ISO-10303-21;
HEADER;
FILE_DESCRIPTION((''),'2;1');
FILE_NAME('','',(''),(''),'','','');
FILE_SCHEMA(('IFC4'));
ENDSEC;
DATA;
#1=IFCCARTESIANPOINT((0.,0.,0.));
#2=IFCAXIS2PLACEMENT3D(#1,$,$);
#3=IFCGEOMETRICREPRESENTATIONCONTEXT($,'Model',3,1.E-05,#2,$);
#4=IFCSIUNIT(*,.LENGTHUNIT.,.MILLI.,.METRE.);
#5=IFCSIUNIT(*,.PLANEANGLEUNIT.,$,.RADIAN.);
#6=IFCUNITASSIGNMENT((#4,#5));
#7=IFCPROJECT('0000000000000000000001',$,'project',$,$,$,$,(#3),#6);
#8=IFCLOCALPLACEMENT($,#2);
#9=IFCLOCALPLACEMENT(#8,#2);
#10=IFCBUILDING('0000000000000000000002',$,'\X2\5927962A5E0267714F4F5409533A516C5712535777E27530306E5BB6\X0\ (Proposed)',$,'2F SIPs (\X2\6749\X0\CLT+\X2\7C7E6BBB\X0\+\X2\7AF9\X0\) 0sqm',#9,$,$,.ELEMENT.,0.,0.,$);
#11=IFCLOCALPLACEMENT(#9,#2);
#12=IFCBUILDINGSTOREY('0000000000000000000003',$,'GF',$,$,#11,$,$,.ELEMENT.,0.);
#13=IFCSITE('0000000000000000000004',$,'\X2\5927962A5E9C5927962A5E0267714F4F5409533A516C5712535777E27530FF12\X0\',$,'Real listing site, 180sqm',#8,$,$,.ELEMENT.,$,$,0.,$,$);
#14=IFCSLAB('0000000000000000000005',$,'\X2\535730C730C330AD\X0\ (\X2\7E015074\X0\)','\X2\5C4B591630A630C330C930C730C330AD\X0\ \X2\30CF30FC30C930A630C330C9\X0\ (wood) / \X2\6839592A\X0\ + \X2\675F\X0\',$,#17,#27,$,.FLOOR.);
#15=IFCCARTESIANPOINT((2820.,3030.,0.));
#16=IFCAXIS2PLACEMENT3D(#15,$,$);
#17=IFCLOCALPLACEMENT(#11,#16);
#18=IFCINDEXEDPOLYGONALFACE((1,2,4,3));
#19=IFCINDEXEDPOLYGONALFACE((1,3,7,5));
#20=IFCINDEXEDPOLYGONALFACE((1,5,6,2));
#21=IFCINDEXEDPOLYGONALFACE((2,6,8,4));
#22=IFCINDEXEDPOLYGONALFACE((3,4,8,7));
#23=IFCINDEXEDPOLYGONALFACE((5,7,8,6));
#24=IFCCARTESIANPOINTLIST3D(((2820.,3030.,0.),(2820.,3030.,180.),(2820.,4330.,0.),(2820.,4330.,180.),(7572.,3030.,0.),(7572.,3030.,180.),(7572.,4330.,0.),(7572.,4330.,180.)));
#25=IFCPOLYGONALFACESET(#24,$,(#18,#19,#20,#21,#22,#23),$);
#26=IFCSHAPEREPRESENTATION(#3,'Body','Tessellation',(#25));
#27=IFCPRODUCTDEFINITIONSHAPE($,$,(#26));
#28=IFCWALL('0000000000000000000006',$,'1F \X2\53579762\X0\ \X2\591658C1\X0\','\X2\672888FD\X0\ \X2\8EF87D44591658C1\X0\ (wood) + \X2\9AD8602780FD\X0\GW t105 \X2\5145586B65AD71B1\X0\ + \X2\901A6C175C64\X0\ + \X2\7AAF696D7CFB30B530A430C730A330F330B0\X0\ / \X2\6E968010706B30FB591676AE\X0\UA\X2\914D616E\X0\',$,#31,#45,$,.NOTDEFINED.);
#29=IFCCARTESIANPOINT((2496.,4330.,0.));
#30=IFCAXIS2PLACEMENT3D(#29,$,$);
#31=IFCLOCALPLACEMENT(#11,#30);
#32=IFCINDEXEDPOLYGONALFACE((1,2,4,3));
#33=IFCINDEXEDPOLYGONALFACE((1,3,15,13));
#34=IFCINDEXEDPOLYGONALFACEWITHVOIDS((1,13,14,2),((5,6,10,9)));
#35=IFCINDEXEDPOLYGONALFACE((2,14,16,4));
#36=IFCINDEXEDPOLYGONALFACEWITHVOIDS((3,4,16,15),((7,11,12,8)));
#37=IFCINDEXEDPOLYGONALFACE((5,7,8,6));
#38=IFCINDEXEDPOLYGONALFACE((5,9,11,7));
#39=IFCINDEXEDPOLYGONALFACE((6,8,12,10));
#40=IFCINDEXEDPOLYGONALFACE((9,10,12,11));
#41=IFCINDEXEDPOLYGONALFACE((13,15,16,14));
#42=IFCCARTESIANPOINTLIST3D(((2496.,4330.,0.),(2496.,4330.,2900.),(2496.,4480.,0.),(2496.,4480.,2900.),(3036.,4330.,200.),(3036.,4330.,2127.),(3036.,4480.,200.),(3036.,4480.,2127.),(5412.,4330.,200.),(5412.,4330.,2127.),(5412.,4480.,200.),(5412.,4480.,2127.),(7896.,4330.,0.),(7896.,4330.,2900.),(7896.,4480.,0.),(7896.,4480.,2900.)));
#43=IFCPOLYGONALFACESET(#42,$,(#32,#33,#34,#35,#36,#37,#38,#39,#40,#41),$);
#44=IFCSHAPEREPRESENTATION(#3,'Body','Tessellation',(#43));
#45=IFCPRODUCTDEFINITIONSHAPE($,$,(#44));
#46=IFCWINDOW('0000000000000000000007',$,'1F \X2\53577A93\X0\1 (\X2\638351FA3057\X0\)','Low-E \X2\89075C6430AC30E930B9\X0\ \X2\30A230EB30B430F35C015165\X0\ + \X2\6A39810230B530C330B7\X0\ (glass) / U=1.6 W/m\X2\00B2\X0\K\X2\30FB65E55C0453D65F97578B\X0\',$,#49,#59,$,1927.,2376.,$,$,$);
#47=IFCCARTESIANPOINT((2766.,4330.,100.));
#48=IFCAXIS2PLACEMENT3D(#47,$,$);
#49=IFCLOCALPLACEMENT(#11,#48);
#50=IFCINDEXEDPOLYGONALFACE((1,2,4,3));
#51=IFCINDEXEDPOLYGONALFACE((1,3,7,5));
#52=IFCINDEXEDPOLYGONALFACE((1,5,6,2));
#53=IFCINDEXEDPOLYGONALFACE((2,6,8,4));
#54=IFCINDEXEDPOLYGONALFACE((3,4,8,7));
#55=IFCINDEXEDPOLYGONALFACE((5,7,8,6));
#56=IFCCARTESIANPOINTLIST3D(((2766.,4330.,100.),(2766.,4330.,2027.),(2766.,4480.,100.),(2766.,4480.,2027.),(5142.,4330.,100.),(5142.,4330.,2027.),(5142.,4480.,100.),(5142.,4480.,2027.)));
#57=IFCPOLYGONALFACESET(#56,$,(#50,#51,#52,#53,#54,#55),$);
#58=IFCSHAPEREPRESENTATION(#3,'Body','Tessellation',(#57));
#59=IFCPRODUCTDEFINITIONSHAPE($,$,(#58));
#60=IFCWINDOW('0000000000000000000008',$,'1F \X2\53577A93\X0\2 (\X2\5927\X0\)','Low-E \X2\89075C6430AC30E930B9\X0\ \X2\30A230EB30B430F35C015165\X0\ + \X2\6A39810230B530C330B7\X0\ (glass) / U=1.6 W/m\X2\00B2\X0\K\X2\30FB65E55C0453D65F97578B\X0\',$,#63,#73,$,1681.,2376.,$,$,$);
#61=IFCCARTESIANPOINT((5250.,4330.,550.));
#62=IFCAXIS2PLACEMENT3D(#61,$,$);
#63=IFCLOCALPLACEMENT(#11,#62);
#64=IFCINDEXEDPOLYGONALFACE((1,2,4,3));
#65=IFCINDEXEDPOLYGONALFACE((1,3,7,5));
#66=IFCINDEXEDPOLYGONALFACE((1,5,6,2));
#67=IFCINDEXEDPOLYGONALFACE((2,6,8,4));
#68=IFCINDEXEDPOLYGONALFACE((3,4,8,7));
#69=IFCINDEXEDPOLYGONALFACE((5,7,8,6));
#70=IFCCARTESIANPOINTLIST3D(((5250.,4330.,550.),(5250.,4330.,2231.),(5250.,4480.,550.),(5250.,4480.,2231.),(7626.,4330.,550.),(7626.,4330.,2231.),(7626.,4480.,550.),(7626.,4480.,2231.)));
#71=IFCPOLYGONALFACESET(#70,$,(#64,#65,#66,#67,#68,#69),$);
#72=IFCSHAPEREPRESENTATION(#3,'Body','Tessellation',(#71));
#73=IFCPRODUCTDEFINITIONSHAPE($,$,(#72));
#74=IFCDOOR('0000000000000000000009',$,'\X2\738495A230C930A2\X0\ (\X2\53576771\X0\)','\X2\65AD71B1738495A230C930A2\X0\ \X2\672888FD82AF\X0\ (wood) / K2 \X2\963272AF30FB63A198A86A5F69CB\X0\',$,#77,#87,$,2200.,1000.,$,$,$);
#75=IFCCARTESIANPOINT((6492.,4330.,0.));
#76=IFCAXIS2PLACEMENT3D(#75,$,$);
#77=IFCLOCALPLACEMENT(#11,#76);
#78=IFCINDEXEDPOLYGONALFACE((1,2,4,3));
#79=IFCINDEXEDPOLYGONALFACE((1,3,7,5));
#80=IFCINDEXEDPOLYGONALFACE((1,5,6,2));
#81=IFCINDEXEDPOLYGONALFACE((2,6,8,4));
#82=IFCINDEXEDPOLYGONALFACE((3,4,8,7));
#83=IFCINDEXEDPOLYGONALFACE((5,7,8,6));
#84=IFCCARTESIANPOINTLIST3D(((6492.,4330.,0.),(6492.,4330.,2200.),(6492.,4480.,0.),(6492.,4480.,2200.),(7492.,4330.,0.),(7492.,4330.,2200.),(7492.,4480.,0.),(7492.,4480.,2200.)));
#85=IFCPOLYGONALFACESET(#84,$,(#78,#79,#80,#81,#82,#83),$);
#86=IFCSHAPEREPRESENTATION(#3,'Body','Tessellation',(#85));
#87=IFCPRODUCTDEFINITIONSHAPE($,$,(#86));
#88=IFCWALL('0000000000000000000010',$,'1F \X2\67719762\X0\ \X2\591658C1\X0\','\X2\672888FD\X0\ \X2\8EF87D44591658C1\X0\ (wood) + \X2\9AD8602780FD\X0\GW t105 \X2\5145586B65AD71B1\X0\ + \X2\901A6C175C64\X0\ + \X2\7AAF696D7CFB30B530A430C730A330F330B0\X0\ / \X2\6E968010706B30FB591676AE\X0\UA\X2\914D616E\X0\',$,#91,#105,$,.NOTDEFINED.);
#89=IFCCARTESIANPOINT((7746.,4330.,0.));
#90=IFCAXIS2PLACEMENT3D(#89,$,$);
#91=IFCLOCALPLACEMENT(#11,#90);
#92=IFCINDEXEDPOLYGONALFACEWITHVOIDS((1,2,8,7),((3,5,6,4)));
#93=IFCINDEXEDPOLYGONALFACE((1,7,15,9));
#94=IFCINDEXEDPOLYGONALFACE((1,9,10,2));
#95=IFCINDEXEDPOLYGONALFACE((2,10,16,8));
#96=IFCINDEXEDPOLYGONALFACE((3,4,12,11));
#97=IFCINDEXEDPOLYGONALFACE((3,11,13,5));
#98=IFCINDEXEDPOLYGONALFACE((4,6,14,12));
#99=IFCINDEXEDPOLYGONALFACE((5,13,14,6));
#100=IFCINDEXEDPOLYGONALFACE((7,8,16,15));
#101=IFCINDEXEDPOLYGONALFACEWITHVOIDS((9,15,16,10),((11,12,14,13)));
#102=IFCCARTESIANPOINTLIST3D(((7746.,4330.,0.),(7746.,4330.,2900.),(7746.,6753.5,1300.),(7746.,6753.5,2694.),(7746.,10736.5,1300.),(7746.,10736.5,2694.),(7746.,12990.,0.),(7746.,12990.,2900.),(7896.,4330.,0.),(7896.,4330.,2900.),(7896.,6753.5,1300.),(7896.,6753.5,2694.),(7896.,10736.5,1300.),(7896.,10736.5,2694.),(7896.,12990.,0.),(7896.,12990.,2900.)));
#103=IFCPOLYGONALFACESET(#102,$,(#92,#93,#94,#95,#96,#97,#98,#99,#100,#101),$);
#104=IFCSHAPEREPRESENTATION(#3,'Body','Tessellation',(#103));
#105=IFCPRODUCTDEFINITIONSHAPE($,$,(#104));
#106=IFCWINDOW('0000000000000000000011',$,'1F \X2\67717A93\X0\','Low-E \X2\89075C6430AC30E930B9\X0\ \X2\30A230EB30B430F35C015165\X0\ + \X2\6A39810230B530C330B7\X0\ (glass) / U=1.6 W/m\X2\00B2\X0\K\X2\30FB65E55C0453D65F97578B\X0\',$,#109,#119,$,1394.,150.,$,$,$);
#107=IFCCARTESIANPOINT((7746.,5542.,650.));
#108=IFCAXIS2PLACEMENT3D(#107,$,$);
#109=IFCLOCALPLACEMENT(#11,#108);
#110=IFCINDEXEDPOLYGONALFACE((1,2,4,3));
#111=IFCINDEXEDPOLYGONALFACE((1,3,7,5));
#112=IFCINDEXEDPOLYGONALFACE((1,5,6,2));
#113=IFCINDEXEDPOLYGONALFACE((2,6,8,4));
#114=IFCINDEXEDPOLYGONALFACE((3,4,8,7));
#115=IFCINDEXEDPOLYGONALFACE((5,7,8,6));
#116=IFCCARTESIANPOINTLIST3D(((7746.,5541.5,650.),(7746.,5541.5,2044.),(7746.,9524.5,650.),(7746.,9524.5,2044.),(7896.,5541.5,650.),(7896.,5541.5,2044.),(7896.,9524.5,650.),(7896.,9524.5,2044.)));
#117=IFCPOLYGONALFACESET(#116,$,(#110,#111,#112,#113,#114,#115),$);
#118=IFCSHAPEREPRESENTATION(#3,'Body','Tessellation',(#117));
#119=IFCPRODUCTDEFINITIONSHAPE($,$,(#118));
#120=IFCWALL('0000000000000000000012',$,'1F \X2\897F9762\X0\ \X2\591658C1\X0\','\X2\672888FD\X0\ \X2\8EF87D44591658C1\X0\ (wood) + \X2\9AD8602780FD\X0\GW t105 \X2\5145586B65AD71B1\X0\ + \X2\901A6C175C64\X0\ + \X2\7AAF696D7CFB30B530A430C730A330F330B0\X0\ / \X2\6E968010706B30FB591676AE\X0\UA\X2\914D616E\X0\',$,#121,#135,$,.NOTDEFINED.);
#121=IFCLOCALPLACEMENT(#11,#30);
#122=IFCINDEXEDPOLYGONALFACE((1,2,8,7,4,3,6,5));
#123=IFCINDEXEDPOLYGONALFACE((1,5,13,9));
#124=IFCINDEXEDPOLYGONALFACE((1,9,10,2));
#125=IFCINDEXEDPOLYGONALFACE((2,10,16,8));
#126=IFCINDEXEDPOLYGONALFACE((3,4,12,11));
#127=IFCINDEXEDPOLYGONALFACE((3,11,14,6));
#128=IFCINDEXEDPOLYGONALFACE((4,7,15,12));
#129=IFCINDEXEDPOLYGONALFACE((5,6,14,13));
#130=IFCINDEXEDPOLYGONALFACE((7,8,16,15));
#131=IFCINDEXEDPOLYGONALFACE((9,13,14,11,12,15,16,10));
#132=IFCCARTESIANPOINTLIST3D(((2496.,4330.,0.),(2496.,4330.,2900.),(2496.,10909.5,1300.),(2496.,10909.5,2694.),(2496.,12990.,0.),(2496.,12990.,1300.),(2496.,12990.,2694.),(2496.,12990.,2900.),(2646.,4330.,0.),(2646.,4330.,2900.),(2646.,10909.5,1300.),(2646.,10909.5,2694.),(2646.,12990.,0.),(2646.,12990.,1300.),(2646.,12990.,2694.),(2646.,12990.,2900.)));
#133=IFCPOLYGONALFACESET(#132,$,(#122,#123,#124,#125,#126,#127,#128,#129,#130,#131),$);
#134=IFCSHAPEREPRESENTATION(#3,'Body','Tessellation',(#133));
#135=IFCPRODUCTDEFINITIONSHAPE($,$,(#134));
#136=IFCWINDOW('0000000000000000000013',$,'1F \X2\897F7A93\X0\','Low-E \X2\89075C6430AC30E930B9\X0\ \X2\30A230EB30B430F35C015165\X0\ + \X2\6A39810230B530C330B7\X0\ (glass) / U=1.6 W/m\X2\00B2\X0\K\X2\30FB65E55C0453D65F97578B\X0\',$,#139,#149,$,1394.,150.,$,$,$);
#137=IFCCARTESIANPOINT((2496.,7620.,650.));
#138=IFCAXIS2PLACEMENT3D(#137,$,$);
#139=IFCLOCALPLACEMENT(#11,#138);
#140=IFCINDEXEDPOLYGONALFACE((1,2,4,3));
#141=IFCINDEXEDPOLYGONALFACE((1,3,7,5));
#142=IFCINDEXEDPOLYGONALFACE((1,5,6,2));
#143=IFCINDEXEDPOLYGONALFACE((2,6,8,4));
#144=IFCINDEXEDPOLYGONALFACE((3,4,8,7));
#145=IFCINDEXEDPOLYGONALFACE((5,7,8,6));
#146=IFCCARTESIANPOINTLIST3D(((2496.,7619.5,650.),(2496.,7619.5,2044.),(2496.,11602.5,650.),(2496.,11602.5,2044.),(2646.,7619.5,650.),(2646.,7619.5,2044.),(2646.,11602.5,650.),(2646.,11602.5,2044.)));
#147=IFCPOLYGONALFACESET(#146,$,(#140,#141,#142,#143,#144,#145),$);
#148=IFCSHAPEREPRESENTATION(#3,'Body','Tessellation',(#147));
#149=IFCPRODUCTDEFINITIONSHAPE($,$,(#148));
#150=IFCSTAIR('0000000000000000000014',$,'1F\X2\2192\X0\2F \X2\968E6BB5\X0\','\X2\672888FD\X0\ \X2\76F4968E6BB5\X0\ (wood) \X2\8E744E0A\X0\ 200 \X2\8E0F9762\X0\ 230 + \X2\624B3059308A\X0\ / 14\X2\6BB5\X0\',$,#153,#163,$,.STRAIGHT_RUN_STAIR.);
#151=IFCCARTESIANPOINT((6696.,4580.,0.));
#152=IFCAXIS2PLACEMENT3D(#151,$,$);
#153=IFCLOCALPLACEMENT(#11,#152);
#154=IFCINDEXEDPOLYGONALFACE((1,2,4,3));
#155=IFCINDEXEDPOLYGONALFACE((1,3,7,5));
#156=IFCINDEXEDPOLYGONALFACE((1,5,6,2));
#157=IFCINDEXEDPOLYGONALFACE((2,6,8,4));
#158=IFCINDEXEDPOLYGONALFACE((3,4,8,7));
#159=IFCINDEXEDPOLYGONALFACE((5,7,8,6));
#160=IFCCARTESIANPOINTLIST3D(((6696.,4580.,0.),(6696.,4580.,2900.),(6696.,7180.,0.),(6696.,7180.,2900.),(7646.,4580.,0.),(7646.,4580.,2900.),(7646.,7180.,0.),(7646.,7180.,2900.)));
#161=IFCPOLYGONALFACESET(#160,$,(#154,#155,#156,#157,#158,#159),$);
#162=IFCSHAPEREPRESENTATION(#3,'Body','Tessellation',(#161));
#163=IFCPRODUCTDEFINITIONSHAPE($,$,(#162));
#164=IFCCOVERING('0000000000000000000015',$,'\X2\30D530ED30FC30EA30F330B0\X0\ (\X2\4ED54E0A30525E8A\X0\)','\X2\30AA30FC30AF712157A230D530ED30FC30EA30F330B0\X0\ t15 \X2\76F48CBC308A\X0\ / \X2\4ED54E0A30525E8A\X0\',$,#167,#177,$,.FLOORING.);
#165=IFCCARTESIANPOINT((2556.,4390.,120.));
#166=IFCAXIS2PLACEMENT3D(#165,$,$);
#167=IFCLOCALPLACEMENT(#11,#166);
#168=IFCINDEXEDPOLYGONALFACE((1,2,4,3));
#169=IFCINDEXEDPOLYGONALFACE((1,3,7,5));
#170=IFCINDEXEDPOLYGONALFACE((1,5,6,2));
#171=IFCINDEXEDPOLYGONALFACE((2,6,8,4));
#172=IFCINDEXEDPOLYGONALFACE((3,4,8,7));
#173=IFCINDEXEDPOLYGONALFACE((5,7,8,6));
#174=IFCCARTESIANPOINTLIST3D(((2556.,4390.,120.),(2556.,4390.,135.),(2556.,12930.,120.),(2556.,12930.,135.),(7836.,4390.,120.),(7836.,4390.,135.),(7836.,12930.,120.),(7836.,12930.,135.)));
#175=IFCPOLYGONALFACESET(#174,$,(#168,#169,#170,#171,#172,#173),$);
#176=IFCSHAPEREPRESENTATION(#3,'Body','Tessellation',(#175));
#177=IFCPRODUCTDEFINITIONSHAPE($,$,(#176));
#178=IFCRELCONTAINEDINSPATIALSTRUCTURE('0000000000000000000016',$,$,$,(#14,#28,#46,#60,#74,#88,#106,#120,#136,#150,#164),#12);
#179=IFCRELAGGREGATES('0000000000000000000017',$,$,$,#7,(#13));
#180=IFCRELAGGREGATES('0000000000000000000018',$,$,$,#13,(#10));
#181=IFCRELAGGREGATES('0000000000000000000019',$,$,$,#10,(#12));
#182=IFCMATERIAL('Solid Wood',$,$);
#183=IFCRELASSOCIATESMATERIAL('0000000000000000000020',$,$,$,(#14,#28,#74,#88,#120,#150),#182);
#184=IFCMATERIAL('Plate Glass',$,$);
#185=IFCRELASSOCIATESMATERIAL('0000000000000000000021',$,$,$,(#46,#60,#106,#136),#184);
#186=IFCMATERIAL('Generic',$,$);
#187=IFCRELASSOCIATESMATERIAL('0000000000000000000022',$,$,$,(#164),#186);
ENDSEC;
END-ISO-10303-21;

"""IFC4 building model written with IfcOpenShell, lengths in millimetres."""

from ifc_helpers import new_model, si_unit, frame, frame_2d, origin, place, context, project, spatial, rectangle, extrude, material, element, fill, save


model = new_model("IFC4")

# Units and contexts
model_context = context("Model", 3, precision=1e-05, world=origin())
ifc_project = project(units=[si_unit("LENGTHUNIT", "METRE", prefix="MILLI"), si_unit("PLANEANGLEUNIT", "RADIAN")], contexts=[model_context])

# Site, building, storey
site_placement = place(None, origin())
site = spatial("IfcSite", under=ifc_project, at=site_placement, Name="大阪府大阪市東住吉区公園南矢田２", ObjectType="Real listing site, 180sqm", CompositionType="ELEMENT", RefElevation=0.0)
building_placement = place(site_placement, origin())
building = spatial("IfcBuilding", under=site, at=building_placement, Name="大阪市東住吉区公園南矢田の家 (Proposed)", ObjectType="2F SIPs (杉CLT+籾殻+竹) 0sqm", CompositionType="ELEMENT", ElevationOfRefHeight=0.0, ElevationOfTerrain=0.0)
storey_placement = place(building_placement, origin())
storey = spatial("IfcBuildingStorey", under=building, at=storey_placement, Name="GF", CompositionType="ELEMENT", Elevation=0.0)

# Slab
ifc_material_1 = material(Name="Solid Wood")
slab_1_placement = place(storey_placement, frame((2820.0, 3030.0, 0.0)))
element("IfcSlab", 1, at=slab_1_placement, inside=storey, material=ifc_material_1, Name="南デッキ (縁側)", Description="屋外ウッドデッキ ハードウッド (wood) / 根太 + 束", PredefinedType="FLOOR", context=model_context, shape_type="SweptSolid", body=[
    extrude(rectangle(XDim=4752.0, YDim=1300.0, at=frame_2d((2376.0, 650.0))), frame((2820.0, 3030.0, 0.0)), (0.0, 0.0, 1.0), 180.0),
])

# Wall, openings, windows, door
wall_1_placement = place(storey_placement, frame((2496.0, 4330.0, 0.0)))
wall_1 = element("IfcWall", 2, at=wall_1_placement, inside=storey, material=ifc_material_1, Name="1F 南面 外壁", Description="木製 軸組外壁 (wood) + 高性能GW t105 充填断熱 + 通気層 + 窯業系サイディング / 準耐火・外皮UA配慮", PredefinedType="NOTDEFINED", context=model_context, shape_type="SweptSolid", body=[
    extrude(rectangle(XDim=5400.0, YDim=150.0, at=frame_2d((2700.0, 75.0))), frame((2496.0, 4330.0, 0.0)), (0.0, 0.0, 1.0), 2900.0),
])
opening_1_placement = place(storey_placement, frame((2766.0, 4330.0, 100.0)))
opening_1 = element("IfcOpeningElement", 3, at=opening_1_placement, cuts=wall_1, PredefinedType="NOTDEFINED", context=model_context, shape_type="SweptSolid", body=[
    extrude(rectangle(XDim=2376.0, YDim=150.0, at=frame_2d((1188.0, 75.0))), frame((2766.0, 4330.0, 100.0)), (0.0, 0.0, 1.0), 1927.0),
])
opening_2_placement = place(storey_placement, frame((5250.0, 4330.0, 550.0)))
opening_2 = element("IfcOpeningElement", 4, at=opening_2_placement, cuts=wall_1, PredefinedType="NOTDEFINED", context=model_context, shape_type="SweptSolid", body=[
    extrude(rectangle(XDim=2376.0, YDim=150.0, at=frame_2d((1188.0, 75.0))), frame((5250.0, 4330.0, 550.0)), (0.0, 0.0, 1.0), 1681.0),
])
opening_3_placement = place(storey_placement, frame((6492.0, 4330.0, 0.0)))
opening_3 = element("IfcOpeningElement", 5, at=opening_3_placement, cuts=wall_1, PredefinedType="NOTDEFINED", context=model_context, shape_type="SweptSolid", body=[
    extrude(rectangle(XDim=1000.0, YDim=150.0, at=frame_2d((500.0, 75.0))), frame((6492.0, 4330.0, 0.0)), (0.0, 0.0, 1.0), 2200.0),
])
ifc_material_2 = material(Name="Plate Glass")
window_1_placement = place(storey_placement, frame((2766.0, 4330.0, 100.0)))
window_1 = element("IfcWindow", 6, at=window_1_placement, inside=storey, material=ifc_material_2, Name="1F 南窓1 (掃出し)", Description="Low-E 複層ガラス アルゴン封入 + 樹脂サッシ (glass) / U=1.6 W/m²K・日射取得型", OverallHeight=1927.0, OverallWidth=2376.0, context=model_context, shape_type="SweptSolid", body=[
    extrude(rectangle(XDim=2376.0, YDim=150.0, at=frame_2d((1188.0, 75.0))), frame((2766.0, 4330.0, 100.0)), (0.0, 0.0, 1.0), 1927.0),
])
fill(opening_1, window_1)
window_2_placement = place(storey_placement, frame((5250.0, 4330.0, 550.0)))
window_2 = element("IfcWindow", 7, at=window_2_placement, inside=storey, material=ifc_material_2, Name="1F 南窓2 (大)", Description="Low-E 複層ガラス アルゴン封入 + 樹脂サッシ (glass) / U=1.6 W/m²K・日射取得型", OverallHeight=1681.0, OverallWidth=2376.0, context=model_context, shape_type="SweptSolid", body=[
    extrude(rectangle(XDim=2376.0, YDim=150.0, at=frame_2d((1188.0, 75.0))), frame((5250.0, 4330.0, 550.0)), (0.0, 0.0, 1.0), 1681.0),
])
fill(opening_2, window_2)
door_placement = place(storey_placement, frame((6492.0, 4330.0, 0.0)))
door = element("IfcDoor", 8, at=door_placement, inside=storey, material=ifc_material_1, Name="玄関ドア (南東)", Description="断熱玄関ドア 木製芯 (wood) / K2 防犯・採風機構", OverallHeight=2200.0, OverallWidth=1000.0, context=model_context, shape_type="SweptSolid", body=[
    extrude(rectangle(XDim=1000.0, YDim=150.0, at=frame_2d((500.0, 75.0))), frame((6492.0, 4330.0, 0.0)), (0.0, 0.0, 1.0), 2200.0),
])
fill(opening_3, door)

# Walls, openings, windows
wall_2_placement = place(storey_placement, frame((7746.0, 4330.0, 0.0)))
wall_2 = element("IfcWall", 9, at=wall_2_placement, inside=storey, material=ifc_material_1, Name="1F 東面 外壁", Description="木製 軸組外壁 (wood) + 高性能GW t105 充填断熱 + 通気層 + 窯業系サイディング / 準耐火・外皮UA配慮", PredefinedType="NOTDEFINED", context=model_context, shape_type="SweptSolid", body=[
    extrude(rectangle(XDim=150.0, YDim=8660.0, at=frame_2d((75.0, 4330.0))), frame((7746.0, 4330.0, 0.0)), (0.0, 0.0, 1.0), 2900.0),
])
opening_4_placement = place(storey_placement, frame((7746.0, 5542.0, 650.0)))
opening_4 = element("IfcOpeningElement", 10, at=opening_4_placement, cuts=wall_2, PredefinedType="NOTDEFINED", context=model_context, shape_type="SweptSolid", body=[
    extrude(rectangle(XDim=150.0, YDim=3983.0, at=frame_2d((75.0, 1991.0))), frame((7746.0, 5542.0, 650.0)), (0.0, 0.0, 1.0), 1394.0),
])
window_3_placement = place(storey_placement, frame((7746.0, 5542.0, 650.0)))
window_3 = element("IfcWindow", 11, at=window_3_placement, inside=storey, material=ifc_material_2, Name="1F 東窓", Description="Low-E 複層ガラス アルゴン封入 + 樹脂サッシ (glass) / U=1.6 W/m²K・日射取得型", OverallHeight=1394.0, OverallWidth=150.0, context=model_context, shape_type="SweptSolid", body=[
    extrude(rectangle(XDim=150.0, YDim=3983.0, at=frame_2d((75.0, 1991.0))), frame((7746.0, 5542.0, 650.0)), (0.0, 0.0, 1.0), 1394.0),
])
fill(opening_4, window_3)
wall_3_placement = place(storey_placement, frame((2496.0, 4330.0, 0.0)))
wall_3 = element("IfcWall", 12, at=wall_3_placement, inside=storey, material=ifc_material_1, Name="1F 西面 外壁", Description="木製 軸組外壁 (wood) + 高性能GW t105 充填断熱 + 通気層 + 窯業系サイディング / 準耐火・外皮UA配慮", PredefinedType="NOTDEFINED", context=model_context, shape_type="SweptSolid", body=[
    extrude(rectangle(XDim=150.0, YDim=8660.0, at=frame_2d((75.0, 4330.0))), frame((2496.0, 4330.0, 0.0)), (0.0, 0.0, 1.0), 2900.0),
])
opening_5_placement = place(storey_placement, frame((2496.0, 7620.0, 650.0)))
opening_5 = element("IfcOpeningElement", 13, at=opening_5_placement, cuts=wall_3, PredefinedType="NOTDEFINED", context=model_context, shape_type="SweptSolid", body=[
    extrude(rectangle(XDim=150.0, YDim=3983.0, at=frame_2d((75.0, 1991.0))), frame((2496.0, 7620.0, 650.0)), (0.0, 0.0, 1.0), 1394.0),
])
window_4_placement = place(storey_placement, frame((2496.0, 7620.0, 650.0)))
window_4 = element("IfcWindow", 14, at=window_4_placement, inside=storey, material=ifc_material_2, Name="1F 西窓", Description="Low-E 複層ガラス アルゴン封入 + 樹脂サッシ (glass) / U=1.6 W/m²K・日射取得型", OverallHeight=1394.0, OverallWidth=150.0, context=model_context, shape_type="SweptSolid", body=[
    extrude(rectangle(XDim=150.0, YDim=3983.0, at=frame_2d((75.0, 1991.0))), frame((2496.0, 7620.0, 650.0)), (0.0, 0.0, 1.0), 1394.0),
])
fill(opening_5, window_4)

# Stair
stair_placement = place(storey_placement, frame((6696.0, 4580.0, 0.0)))
element("IfcStair", 15, at=stair_placement, inside=storey, material=ifc_material_1, Name="1F→2F 階段", Description="木製 直階段 (wood) 蹴上 200 踏面 230 + 手すり / 14段", PredefinedType="STRAIGHT_RUN_STAIR", context=model_context, shape_type="SweptSolid", body=[
    extrude(rectangle(XDim=950.0, YDim=2600.0, at=frame_2d((475.0, 1300.0))), frame((6696.0, 4580.0, 0.0)), (0.0, 0.0, 1.0), 2900.0),
])

# Covering
ifc_material_3 = material(Name="Generic")
covering_placement = place(storey_placement, frame((2556.0, 4390.0, 120.0)))
element("IfcCovering", 16, at=covering_placement, inside=storey, material=ifc_material_3, Name="フローリング (仕上げ床)", Description="オーク無垢フローリング t15 直貼り / 仕上げ床", PredefinedType="FLOORING", context=model_context, shape_type="SweptSolid", body=[
    extrude(rectangle(XDim=5280.0, YDim=8540.0, at=frame_2d((2640.0, 4270.0))), frame((2556.0, 4390.0, 120.0)), (0.0, 0.0, 1.0), 15.0),
])

save(model, "model.ifc")
